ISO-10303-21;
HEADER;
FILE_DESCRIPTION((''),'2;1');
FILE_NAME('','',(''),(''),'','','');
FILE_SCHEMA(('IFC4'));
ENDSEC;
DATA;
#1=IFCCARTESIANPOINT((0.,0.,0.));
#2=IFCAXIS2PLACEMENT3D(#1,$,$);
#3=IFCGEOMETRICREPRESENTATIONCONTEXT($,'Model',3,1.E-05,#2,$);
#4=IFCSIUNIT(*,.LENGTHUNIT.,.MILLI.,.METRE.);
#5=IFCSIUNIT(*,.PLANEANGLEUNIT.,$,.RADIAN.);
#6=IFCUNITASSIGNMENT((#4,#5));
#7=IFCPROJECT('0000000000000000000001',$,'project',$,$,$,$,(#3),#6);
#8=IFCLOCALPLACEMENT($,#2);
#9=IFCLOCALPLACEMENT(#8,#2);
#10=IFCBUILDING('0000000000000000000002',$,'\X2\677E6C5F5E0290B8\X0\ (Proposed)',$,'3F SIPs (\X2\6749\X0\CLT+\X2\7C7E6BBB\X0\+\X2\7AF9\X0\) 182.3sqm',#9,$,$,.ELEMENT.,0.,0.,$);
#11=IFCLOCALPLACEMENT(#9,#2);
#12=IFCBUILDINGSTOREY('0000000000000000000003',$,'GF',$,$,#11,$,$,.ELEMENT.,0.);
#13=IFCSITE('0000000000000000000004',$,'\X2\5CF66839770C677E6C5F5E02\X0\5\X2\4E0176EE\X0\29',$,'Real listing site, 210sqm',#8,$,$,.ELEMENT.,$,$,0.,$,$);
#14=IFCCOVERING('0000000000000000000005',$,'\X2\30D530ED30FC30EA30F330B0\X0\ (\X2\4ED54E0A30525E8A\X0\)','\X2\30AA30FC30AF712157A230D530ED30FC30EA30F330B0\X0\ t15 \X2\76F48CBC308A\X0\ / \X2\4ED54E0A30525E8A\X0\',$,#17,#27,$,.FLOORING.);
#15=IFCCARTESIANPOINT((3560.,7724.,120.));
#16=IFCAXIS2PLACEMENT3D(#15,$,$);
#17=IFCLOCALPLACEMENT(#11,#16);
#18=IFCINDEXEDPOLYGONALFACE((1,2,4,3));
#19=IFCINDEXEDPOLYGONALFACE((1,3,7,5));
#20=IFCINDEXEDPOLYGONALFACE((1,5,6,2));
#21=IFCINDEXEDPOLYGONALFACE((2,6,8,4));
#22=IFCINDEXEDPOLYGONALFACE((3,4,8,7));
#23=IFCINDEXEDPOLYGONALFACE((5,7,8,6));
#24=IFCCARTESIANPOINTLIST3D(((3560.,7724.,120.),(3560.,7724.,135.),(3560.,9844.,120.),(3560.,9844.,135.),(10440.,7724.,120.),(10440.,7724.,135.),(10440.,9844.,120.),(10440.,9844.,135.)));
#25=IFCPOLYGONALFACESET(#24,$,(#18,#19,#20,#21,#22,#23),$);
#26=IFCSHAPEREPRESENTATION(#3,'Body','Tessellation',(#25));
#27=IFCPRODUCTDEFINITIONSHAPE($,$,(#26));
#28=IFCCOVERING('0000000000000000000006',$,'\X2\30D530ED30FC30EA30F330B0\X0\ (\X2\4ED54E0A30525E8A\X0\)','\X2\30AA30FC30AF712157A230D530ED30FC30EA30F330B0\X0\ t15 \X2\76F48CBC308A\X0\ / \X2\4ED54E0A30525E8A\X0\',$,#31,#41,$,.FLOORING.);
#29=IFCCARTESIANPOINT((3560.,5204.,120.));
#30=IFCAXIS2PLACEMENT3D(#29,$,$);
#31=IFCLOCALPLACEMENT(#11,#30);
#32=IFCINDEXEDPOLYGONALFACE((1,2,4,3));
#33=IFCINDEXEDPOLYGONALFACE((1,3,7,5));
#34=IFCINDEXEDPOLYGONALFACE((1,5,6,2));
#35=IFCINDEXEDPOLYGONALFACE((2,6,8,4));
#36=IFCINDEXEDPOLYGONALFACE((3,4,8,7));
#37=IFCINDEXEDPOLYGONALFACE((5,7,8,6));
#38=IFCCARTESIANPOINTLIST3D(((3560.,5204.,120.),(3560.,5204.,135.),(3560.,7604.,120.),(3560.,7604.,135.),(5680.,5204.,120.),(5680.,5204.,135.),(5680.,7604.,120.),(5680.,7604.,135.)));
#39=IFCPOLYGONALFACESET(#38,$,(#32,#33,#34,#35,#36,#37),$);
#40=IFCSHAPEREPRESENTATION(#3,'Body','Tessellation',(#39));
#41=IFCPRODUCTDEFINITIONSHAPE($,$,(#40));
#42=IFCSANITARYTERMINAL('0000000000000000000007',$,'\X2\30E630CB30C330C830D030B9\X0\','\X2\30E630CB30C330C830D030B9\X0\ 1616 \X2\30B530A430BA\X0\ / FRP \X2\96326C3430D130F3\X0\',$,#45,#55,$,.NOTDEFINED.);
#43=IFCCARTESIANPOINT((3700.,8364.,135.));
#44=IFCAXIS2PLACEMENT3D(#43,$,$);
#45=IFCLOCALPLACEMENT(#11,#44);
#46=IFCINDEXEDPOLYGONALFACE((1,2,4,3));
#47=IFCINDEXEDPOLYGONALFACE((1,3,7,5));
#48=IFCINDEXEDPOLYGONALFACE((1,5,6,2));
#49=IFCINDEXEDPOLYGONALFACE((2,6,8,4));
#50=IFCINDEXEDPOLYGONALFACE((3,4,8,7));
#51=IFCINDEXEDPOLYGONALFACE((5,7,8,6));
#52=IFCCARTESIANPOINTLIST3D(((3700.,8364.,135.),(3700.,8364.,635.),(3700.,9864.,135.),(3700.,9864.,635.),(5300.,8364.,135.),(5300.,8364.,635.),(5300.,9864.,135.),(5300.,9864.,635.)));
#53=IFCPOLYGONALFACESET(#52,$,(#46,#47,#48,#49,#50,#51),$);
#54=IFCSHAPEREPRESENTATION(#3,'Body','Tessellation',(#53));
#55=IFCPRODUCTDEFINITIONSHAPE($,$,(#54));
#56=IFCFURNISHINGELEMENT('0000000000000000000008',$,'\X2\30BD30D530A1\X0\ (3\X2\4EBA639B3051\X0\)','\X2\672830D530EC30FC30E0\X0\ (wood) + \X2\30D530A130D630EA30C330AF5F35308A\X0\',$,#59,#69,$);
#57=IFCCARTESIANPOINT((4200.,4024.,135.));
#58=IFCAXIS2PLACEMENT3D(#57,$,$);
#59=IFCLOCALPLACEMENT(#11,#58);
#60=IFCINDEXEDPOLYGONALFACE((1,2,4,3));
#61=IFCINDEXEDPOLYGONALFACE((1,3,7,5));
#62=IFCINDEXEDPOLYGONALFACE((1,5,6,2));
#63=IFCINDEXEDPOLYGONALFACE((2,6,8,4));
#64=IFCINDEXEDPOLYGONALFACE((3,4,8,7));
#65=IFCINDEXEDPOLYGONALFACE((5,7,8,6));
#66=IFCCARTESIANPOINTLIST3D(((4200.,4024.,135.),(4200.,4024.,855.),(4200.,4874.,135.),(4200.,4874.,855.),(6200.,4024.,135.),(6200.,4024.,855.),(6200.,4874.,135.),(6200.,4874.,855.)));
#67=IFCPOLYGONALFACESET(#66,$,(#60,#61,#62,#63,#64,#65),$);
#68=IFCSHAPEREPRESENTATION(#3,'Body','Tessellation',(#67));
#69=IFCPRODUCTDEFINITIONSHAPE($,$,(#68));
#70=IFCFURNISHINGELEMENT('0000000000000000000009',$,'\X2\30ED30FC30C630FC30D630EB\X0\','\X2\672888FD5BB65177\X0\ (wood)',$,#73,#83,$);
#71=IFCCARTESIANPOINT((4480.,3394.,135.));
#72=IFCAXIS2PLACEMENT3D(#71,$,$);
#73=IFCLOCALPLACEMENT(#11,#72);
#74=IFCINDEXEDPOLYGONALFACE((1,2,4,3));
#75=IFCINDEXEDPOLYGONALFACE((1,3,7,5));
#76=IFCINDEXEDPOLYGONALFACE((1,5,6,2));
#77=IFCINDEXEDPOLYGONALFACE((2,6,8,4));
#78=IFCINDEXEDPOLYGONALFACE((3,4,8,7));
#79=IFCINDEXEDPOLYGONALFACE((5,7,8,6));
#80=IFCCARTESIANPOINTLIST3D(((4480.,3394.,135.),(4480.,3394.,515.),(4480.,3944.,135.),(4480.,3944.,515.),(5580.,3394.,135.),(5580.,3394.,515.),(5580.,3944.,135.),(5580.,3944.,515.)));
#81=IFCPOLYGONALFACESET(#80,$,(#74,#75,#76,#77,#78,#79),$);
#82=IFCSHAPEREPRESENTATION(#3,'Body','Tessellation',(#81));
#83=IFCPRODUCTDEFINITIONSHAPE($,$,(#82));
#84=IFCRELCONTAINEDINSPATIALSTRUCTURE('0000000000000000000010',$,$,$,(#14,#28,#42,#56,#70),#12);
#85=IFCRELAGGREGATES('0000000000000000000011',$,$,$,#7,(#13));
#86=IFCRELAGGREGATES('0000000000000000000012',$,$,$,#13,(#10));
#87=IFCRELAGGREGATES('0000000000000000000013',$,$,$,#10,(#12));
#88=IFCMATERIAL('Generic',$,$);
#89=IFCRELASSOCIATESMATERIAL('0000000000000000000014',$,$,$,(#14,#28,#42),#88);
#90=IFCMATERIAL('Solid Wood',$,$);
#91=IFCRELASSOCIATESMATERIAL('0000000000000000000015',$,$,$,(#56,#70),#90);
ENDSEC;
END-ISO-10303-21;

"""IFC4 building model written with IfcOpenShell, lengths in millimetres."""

from ifc_helpers import new_model, si_unit, frame, frame_2d, origin, place, context, project, spatial, rectangle, extrude, material, element, save


model = new_model("IFC4")

# Units and contexts
model_context = context("Model", 3, precision=1e-05, world=origin())
ifc_project = project(units=[si_unit("LENGTHUNIT", "METRE", prefix="MILLI"), si_unit("PLANEANGLEUNIT", "RADIAN")], contexts=[model_context])

# Site, building, storey
site_placement = place(None, origin())
site = spatial("IfcSite", under=ifc_project, at=site_placement, Name="島根県松江市5丁目29", ObjectType="Real listing site, 210sqm", CompositionType="ELEMENT", RefElevation=0.0)
building_placement = place(site_placement, origin())
building = spatial("IfcBuilding", under=site, at=building_placement, Name="松江市邸 (Proposed)", ObjectType="3F SIPs (杉CLT+籾殻+竹) 182.3sqm", CompositionType="ELEMENT", ElevationOfRefHeight=0.0, ElevationOfTerrain=0.0)
storey_placement = place(building_placement, origin())
storey = spatial("IfcBuildingStorey", under=building, at=storey_placement, Name="GF", CompositionType="ELEMENT", Elevation=0.0)

# Shared definitions
ifc_material_1 = material(Name="Solid Wood")

# Coverings
ifc_material_2 = material(Name="Generic")
covering_1_placement = place(storey_placement, frame((3560.0, 7724.0, 120.0)))
element("IfcCovering", 1, at=covering_1_placement, inside=storey, material=ifc_material_2, Name="フローリング (仕上げ床)", Description="オーク無垢フローリング t15 直貼り / 仕上げ床", PredefinedType="FLOORING", context=model_context, shape_type="SweptSolid", body=[
    extrude(rectangle(XDim=6880.0, YDim=2120.0, at=frame_2d((3440.0, 1060.0))), frame((3560.0, 7724.0, 120.0)), (0.0, 0.0, 1.0), 15.0),
])
covering_2_placement = place(storey_placement, frame((3560.0, 5204.0, 120.0)))
element("IfcCovering", 2, at=covering_2_placement, inside=storey, material=ifc_material_2, Name="フローリング (仕上げ床)", Description="オーク無垢フローリング t15 直貼り / 仕上げ床", PredefinedType="FLOORING", context=model_context, shape_type="SweptSolid", body=[
    extrude(rectangle(XDim=2120.0, YDim=2400.0, at=frame_2d((1060.0, 1200.0))), frame((3560.0, 5204.0, 120.0)), (0.0, 0.0, 1.0), 15.0),
])

# Sanitary terminal
sanitary_terminal_placement = place(storey_placement, frame((3700.0, 8364.0, 135.0)))
element("IfcSanitaryTerminal", 3, at=sanitary_terminal_placement, inside=storey, material=ifc_material_2, Name="ユニットバス", Description="ユニットバス 1616 サイズ / FRP 防水パン", PredefinedType="NOTDEFINED", context=model_context, shape_type="SweptSolid", body=[
    extrude(rectangle(XDim=1600.0, YDim=1500.0, at=frame_2d((800.0, 750.0))), frame((3700.0, 8364.0, 135.0)), (0.0, 0.0, 1.0), 500.0),
])

# Furnishing elements
furnishing_1_placement = place(storey_placement, frame((4200.0, 4024.0, 135.0)))
element("IfcFurnishingElement", 4, at=furnishing_1_placement, inside=storey, material=ifc_material_1, Name="ソファ (3人掛け)", Description="木フレーム (wood) + ファブリック張り", context=model_context, shape_type="SweptSolid", body=[
    extrude(rectangle(XDim=2000.0, YDim=850.0, at=frame_2d((1000.0, 425.0))), frame((4200.0, 4024.0, 135.0)), (0.0, 0.0, 1.0), 720.0),
])
furnishing_2_placement = place(storey_placement, frame((4480.0, 3394.0, 135.0)))
element("IfcFurnishingElement", 5, at=furnishing_2_placement, inside=storey, material=ifc_material_1, Name="ローテーブル", Description="木製家具 (wood)", context=model_context, shape_type="SweptSolid", body=[
    extrude(rectangle(XDim=1100.0, YDim=550.0, at=frame_2d((550.0, 275.0))), frame((4480.0, 3394.0, 135.0)), (0.0, 0.0, 1.0), 380.0),
])

save(model, "model.ifc")
